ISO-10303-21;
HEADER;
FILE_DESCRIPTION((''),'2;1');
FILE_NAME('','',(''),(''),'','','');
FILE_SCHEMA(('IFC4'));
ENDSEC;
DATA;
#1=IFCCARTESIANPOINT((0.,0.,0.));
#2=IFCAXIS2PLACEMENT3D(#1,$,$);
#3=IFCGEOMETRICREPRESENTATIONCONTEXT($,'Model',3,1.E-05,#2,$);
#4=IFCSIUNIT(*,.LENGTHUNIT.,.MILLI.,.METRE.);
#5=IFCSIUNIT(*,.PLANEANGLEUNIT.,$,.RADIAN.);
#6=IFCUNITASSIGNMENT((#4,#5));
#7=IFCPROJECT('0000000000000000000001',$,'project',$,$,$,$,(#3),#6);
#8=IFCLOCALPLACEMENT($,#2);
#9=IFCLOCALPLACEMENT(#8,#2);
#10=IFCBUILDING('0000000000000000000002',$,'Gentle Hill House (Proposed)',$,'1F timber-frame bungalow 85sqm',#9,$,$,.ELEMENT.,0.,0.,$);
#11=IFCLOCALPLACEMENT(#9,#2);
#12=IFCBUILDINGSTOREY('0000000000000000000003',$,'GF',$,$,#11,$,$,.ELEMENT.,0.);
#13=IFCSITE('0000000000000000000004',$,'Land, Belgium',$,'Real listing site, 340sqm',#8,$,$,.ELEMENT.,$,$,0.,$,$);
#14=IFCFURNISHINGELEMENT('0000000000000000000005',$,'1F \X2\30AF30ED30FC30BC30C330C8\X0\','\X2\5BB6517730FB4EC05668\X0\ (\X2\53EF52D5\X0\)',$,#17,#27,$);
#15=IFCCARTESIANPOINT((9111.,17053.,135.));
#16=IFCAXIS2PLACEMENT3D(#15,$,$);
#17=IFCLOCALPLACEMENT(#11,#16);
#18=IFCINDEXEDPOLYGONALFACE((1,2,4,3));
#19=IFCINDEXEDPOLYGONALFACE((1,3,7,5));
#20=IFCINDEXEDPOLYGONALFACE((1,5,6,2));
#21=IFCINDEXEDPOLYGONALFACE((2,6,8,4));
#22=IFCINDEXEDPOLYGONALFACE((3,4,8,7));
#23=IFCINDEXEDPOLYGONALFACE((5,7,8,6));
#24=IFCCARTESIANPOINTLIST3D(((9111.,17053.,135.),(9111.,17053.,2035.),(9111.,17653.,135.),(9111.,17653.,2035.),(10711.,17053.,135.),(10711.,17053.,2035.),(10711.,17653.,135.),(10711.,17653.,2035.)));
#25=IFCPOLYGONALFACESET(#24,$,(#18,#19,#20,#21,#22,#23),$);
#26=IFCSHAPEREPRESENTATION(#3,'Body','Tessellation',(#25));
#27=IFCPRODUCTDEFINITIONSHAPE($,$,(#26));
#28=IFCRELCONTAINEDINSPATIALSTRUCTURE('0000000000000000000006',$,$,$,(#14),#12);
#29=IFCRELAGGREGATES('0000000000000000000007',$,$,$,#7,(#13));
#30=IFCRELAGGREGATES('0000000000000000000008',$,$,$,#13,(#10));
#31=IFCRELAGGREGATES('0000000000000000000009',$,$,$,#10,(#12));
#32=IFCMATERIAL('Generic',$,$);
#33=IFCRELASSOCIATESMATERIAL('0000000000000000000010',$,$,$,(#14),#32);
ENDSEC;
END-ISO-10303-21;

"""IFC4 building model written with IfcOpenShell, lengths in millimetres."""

from ifc_helpers import new_model, si_unit, frame, frame_2d, origin, place, context, project, spatial, rectangle, extrude, material, element, save


model = new_model("IFC4")

# Units and contexts
model_context = context("Model", 3, precision=1e-05, world=origin())
ifc_project = project(units=[si_unit("LENGTHUNIT", "METRE", prefix="MILLI"), si_unit("PLANEANGLEUNIT", "RADIAN")], contexts=[model_context])

# Site, building, storey
site_placement = place(None, origin())
site = spatial("IfcSite", under=ifc_project, at=site_placement, Name="Land, Belgium", ObjectType="Real listing site, 340sqm", CompositionType="ELEMENT", RefElevation=0.0)
building_placement = place(site_placement, origin())
building = spatial("IfcBuilding", under=site, at=building_placement, Name="Gentle Hill House (Proposed)", ObjectType="1F timber-frame bungalow 85sqm", CompositionType="ELEMENT", ElevationOfRefHeight=0.0, ElevationOfTerrain=0.0)
storey_placement = place(building_placement, origin())
storey = spatial("IfcBuildingStorey", under=building, at=storey_placement, Name="GF", CompositionType="ELEMENT", Elevation=0.0)

# Shared definitions
ifc_material_1 = material(Name="Generic")

# Furnishing element
furnishing_placement = place(storey_placement, frame((9111.0, 17053.0, 135.0)))
element("IfcFurnishingElement", 1, at=furnishing_placement, inside=storey, material=ifc_material_1, Name="1F クローゼット", Description="家具・什器 (可動)", context=model_context, shape_type="SweptSolid", body=[
    extrude(rectangle(XDim=1600.0, YDim=600.0, at=frame_2d((800.0, 300.0))), frame((9111.0, 17053.0, 135.0)), (0.0, 0.0, 1.0), 1900.0),
])

save(model, "model.ifc")
